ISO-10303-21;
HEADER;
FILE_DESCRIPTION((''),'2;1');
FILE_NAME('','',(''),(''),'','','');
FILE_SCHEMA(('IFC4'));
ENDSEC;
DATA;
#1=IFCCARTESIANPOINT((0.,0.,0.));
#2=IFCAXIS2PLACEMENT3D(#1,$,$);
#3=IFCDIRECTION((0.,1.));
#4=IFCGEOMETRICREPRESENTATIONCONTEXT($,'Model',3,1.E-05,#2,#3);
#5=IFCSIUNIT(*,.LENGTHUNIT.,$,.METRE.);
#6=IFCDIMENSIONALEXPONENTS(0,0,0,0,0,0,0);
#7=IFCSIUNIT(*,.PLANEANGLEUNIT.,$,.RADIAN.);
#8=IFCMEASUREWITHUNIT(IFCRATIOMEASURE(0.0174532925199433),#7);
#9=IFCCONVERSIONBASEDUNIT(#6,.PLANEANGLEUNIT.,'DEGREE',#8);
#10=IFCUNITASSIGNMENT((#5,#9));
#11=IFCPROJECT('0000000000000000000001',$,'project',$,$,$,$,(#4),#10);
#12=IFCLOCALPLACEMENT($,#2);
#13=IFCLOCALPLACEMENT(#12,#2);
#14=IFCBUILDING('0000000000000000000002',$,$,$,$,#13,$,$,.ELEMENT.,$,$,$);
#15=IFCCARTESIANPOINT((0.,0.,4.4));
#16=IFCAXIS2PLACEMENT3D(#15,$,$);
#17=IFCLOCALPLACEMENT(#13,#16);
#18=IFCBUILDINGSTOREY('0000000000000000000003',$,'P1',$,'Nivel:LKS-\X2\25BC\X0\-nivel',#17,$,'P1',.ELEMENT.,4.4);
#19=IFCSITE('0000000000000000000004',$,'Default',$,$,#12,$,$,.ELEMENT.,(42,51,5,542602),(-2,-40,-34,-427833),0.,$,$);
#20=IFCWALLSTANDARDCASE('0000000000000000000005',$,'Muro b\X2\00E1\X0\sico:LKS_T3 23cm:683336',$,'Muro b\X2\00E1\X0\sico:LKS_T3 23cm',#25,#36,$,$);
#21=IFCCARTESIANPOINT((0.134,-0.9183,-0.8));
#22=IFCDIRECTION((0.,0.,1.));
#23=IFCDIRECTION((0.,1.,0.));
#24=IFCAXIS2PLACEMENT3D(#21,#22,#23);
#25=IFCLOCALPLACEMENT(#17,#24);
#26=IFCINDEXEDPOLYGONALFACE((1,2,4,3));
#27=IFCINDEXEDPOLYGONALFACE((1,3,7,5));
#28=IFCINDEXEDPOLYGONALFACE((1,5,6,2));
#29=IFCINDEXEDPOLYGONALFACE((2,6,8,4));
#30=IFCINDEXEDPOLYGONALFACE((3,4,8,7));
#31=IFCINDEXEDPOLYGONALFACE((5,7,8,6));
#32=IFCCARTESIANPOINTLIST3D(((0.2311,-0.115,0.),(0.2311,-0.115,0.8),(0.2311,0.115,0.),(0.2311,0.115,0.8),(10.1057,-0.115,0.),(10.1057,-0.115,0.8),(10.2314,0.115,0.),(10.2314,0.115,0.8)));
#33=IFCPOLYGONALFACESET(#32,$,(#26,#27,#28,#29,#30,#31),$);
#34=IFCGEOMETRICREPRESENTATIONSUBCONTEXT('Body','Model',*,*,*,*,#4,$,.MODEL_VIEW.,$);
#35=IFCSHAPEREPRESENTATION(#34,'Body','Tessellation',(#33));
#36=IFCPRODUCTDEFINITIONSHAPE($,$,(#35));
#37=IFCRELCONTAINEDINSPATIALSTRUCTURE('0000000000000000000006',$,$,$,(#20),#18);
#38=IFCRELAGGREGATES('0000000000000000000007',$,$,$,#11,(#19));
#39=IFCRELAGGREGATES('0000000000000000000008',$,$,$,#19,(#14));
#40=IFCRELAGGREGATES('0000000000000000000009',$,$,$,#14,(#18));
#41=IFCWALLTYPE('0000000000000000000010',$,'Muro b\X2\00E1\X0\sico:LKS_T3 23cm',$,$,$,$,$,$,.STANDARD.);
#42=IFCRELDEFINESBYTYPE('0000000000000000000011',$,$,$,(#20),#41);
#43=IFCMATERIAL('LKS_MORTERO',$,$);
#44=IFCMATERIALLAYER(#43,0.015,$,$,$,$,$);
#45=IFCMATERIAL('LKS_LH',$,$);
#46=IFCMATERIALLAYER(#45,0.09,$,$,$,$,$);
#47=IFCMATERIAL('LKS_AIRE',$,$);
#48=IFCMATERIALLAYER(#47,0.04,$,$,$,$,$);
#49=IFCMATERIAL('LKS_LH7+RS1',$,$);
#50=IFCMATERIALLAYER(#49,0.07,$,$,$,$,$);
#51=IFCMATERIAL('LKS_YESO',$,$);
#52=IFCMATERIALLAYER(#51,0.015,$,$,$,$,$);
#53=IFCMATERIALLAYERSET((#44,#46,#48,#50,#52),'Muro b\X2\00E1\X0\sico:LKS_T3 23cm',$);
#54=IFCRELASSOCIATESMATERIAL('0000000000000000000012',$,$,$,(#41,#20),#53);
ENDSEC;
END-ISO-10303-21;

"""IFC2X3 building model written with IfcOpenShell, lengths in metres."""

from ifc_helpers import new_model, entity, si_unit, converted_unit, direction, frame, origin, place, context, subcontext, project, spatial, polyline, outline, extrude, material, layer, layer_set, layer_usage, type_object, element, save


model = new_model("IFC2X3")

# Units and contexts
model_context = context("Model", 3, precision=1e-05, world=origin(), true_north=direction((0.0, 1.0)))
body_context = subcontext(model_context, "Body", "Model", "MODEL_VIEW")
ifc_project = project(units=[si_unit("LENGTHUNIT", "METRE"), converted_unit("PLANEANGLEUNIT", "DEGREE", entity("IfcRatioMeasure", 0.0174532925199433), si_unit("PLANEANGLEUNIT", "RADIAN"), dimensions=[0, 0, 0, 0, 0, 0, 0])], contexts=[model_context])

# Site, building, storey
site_placement = place(None, origin())
site = spatial("IfcSite", under=ifc_project, at=site_placement, Name="Default", CompositionType="ELEMENT", RefLatitude=(42, 51, 5, 542602), RefLongitude=(-2, -40, -34, -427833), RefElevation=0.0)
building_placement = place(site_placement, origin())
building = spatial("IfcBuilding", under=site, at=building_placement, CompositionType="ELEMENT")
storey_placement = place(building_placement, frame((0.0, 0.0, 4.4)))
storey = spatial("IfcBuildingStorey", under=building, at=storey_placement, Name="P1", ObjectType="Nivel:LKS-▼-nivel", LongName="P1", CompositionType="ELEMENT", Elevation=4.4)

# Shared definitions
ifc_material_1 = material(Name="LKS_MORTERO")
ifc_material_2 = material(Name="LKS_LH")
ifc_material_3 = material(Name="LKS_AIRE")
ifc_material_4 = material(Name="LKS_YESO")

# Shared definitions
ifc_layer_1 = layer(ifc_material_1, 0.015)
ifc_layer_2 = layer(ifc_material_2, 0.09)
ifc_layer_3 = layer(ifc_material_3, 0.04)
ifc_material_5 = material(Name="LKS_LH7+RS1")
ifc_layer_4 = layer(ifc_material_5, 0.07)
ifc_layer_5 = layer(ifc_material_4, 0.015)
ifc_layer_set_1 = layer_set([ifc_layer_1, ifc_layer_2, ifc_layer_3, ifc_layer_4, ifc_layer_5], Name="Muro básico:LKS_T3 23cm")
wall_type_1 = type_object("IfcWallType", Name="Muro básico:LKS_T3 23cm", PredefinedType="STANDARD", material=ifc_layer_set_1)

# Wall
ifc_layer_usage_1 = layer_usage(ifc_layer_set_1, "AXIS2", "NEGATIVE", 0.115)
wall_1_placement = place(storey_placement, frame((0.134, -0.9183, -0.8), z_axis=(0.0, 0.0, 1.0), x_axis=(0.0, 1.0, 0.0)))
element("IfcWallStandardCase", 1, at=wall_1_placement, inside=storey, type_object=wall_type_1, material=ifc_layer_usage_1, Name="Muro básico:LKS_T3 23cm:683336", ObjectType="Muro básico:LKS_T3 23cm", context=body_context, shape_type="SweptSolid", body=[
    extrude(outline(polyline([(10.1057, -0.115), (10.2314, 0.115), (0.2311, 0.115), (0.2311, -0.115), (10.1057, -0.115)])), origin(), (0.0, 0.0, 1.0), 0.8),
])

save(model, "model.ifc")
